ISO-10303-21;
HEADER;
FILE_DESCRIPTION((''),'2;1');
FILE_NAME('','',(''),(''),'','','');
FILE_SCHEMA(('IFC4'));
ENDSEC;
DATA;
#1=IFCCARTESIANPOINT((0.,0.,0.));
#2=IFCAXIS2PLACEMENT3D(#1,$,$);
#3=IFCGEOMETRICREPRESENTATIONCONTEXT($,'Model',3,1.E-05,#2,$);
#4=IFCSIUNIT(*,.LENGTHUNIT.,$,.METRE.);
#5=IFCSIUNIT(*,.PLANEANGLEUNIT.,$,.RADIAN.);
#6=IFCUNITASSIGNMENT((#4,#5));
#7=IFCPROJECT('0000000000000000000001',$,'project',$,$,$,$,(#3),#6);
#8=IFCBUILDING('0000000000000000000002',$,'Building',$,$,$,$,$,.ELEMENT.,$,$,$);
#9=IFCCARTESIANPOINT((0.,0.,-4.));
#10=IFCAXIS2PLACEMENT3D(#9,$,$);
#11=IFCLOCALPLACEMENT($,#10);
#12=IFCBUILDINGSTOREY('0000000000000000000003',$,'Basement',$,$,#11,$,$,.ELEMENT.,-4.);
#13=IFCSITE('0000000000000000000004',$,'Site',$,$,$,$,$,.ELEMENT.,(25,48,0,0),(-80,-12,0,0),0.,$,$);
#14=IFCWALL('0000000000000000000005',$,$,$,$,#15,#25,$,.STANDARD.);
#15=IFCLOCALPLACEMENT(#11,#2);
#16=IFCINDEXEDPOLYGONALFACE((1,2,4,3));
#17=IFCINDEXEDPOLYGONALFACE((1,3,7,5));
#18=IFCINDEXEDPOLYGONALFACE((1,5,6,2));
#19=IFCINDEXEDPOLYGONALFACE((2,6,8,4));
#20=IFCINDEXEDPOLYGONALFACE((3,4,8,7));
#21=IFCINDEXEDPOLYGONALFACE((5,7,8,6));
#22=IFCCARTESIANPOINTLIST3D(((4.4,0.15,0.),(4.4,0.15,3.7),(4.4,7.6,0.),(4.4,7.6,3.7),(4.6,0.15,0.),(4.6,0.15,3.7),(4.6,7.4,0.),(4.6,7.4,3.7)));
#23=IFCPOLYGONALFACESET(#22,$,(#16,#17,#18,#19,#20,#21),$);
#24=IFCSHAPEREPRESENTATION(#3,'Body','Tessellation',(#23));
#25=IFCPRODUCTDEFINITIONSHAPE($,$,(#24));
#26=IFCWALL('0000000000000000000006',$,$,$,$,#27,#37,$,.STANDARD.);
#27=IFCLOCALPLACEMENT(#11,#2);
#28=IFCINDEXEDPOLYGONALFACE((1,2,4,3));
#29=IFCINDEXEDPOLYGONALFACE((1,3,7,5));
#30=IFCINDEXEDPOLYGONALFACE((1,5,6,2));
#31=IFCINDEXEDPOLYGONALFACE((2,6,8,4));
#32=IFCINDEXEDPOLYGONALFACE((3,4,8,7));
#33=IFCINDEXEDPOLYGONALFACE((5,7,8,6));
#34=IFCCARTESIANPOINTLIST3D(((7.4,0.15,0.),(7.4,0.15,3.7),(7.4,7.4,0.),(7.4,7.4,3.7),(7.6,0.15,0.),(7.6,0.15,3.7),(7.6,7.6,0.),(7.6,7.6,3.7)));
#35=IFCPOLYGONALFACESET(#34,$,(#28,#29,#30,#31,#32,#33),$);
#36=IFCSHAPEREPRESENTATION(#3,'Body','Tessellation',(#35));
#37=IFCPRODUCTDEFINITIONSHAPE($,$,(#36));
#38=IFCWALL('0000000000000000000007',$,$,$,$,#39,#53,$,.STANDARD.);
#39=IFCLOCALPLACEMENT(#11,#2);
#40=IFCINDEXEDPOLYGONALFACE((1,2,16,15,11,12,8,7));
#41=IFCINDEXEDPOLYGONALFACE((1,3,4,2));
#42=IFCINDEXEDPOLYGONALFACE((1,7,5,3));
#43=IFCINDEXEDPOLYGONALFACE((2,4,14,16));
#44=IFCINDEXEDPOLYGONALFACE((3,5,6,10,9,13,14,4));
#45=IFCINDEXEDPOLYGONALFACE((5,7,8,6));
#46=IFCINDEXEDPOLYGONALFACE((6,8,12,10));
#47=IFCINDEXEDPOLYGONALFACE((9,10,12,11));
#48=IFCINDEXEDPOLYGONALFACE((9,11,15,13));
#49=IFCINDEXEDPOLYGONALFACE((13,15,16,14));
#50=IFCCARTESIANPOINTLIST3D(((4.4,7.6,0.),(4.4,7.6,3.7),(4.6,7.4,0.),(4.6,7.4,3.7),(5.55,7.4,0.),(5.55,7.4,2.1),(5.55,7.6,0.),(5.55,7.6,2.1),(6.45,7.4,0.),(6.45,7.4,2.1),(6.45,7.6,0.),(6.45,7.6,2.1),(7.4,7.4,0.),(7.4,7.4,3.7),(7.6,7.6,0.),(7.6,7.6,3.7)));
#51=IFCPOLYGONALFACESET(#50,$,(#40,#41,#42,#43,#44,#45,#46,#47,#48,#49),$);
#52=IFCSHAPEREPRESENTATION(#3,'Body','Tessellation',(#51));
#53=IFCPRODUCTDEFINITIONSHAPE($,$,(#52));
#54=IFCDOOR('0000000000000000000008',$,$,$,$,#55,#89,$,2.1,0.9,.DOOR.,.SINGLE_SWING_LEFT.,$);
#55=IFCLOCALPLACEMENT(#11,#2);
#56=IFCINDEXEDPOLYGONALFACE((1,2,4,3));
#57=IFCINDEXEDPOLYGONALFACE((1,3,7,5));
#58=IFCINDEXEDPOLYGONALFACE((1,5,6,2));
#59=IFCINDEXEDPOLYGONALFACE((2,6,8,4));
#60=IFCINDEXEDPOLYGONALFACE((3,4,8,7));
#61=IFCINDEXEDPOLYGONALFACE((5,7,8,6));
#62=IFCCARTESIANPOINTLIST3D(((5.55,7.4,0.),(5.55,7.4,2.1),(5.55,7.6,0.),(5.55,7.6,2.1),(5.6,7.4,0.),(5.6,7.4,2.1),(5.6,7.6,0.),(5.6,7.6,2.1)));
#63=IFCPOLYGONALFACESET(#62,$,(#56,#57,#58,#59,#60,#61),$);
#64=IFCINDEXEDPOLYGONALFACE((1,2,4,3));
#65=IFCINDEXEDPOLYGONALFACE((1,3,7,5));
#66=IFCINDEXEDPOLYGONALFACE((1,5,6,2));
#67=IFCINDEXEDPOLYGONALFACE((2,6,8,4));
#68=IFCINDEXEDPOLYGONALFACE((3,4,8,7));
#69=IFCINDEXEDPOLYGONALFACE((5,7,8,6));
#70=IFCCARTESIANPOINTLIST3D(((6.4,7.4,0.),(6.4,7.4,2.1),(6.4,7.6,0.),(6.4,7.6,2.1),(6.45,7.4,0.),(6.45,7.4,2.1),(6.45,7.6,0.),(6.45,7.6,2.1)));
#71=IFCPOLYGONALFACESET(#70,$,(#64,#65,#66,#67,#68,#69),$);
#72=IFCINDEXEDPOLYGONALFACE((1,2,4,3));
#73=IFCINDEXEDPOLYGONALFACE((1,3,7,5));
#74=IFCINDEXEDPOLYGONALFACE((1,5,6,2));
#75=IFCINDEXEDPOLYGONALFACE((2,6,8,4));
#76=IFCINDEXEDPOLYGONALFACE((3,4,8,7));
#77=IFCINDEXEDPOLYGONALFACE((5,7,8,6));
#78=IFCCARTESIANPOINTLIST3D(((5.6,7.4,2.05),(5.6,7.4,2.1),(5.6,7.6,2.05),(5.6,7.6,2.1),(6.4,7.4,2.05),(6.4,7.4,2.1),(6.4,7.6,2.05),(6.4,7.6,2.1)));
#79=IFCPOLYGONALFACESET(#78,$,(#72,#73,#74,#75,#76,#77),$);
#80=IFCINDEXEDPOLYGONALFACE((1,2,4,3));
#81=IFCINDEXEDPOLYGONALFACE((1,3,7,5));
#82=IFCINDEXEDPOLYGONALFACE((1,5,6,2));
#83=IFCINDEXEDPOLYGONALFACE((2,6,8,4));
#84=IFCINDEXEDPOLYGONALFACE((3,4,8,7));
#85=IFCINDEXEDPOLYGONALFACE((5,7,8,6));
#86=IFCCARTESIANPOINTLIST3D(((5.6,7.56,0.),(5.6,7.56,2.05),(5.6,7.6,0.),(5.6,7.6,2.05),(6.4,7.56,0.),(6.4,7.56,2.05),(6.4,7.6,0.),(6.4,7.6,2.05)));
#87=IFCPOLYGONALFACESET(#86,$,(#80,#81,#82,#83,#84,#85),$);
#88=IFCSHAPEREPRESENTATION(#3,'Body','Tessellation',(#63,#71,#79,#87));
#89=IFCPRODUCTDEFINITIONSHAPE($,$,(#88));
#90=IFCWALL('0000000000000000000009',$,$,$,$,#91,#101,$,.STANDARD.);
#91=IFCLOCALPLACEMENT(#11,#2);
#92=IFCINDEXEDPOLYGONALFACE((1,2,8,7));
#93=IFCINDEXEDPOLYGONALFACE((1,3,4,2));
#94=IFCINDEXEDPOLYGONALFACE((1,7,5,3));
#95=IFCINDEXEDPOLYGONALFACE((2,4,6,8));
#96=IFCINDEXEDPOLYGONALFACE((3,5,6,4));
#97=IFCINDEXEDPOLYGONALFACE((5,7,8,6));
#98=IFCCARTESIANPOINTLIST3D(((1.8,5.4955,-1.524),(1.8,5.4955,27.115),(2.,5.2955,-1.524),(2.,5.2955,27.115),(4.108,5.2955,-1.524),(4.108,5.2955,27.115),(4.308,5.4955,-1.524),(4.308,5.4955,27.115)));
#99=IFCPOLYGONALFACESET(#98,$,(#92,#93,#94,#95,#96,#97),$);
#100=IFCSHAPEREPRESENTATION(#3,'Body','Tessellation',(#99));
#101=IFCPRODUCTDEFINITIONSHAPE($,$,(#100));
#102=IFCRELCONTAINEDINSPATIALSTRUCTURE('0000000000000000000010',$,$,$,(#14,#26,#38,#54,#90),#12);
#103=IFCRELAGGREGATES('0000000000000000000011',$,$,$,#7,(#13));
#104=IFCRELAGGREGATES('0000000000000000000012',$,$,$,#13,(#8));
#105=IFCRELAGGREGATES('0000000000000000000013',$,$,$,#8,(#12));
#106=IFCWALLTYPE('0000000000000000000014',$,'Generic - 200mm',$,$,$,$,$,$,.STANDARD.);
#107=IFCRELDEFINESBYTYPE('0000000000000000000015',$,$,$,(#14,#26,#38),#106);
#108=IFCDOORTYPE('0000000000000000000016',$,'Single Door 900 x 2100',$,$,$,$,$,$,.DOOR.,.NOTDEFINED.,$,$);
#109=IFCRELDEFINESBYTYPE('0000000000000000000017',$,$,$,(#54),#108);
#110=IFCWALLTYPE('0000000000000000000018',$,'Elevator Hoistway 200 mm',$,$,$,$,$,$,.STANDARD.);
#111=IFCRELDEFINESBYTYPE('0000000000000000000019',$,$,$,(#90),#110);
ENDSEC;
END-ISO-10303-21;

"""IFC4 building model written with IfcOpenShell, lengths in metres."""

from ifc_helpers import new_model, si_unit, frame, frame_2d, origin, origin_with_axes, origin_2d, place, context, project, spatial, polyline, rectangle, outline, extrude, type_object, element, fill, save


model = new_model("IFC4")

# Units and contexts
model_context = context("Model", 3, precision=1e-05, world=origin())
ifc_project = project(units=[si_unit("LENGTHUNIT", "METRE"), si_unit("PLANEANGLEUNIT", "RADIAN")], contexts=[model_context])

# Site, building, storey
site = spatial("IfcSite", under=ifc_project, Name="Site", CompositionType="ELEMENT", RefLatitude=(25, 48, 0, 0), RefLongitude=(-80, -12, 0, 0), RefElevation=0.0)
building = spatial("IfcBuilding", under=site, Name="Building", CompositionType="ELEMENT")
storey_placement = place(None, frame((0.0, 0.0, -4.0)))
storey = spatial("IfcBuildingStorey", under=building, at=storey_placement, Name="Basement", CompositionType="ELEMENT", Elevation=-4.0)

# Walls
wall_type_1 = type_object("IfcWallType", Name="Generic - 200mm", PredefinedType="STANDARD")
wall_1_placement = place(None, frame((4.5, 7.5, -4.0), z_axis=(0.0, 0.0, 1.0), x_axis=(0.0, -1.0, 0.0)))
element("IfcWall", 1, at=wall_1_placement, inside=storey, type_object=wall_type_1, PredefinedType="STANDARD", context=model_context, shape_type="SweptSolid", body=[
    extrude(outline(polyline([(-0.1, -0.1), (7.35, -0.1), (7.35, 0.1), (0.1, 0.1), (-0.1, -0.1)])), origin(), (0.0, 0.0, 1.0), 3.7),
])
wall_2_placement = place(None, frame((7.5, 7.5, -4.0), z_axis=(0.0, 0.0, 1.0), x_axis=(0.0, -1.0, 0.0)))
element("IfcWall", 2, at=wall_2_placement, inside=storey, type_object=wall_type_1, PredefinedType="STANDARD", context=model_context, shape_type="SweptSolid", body=[
    extrude(outline(polyline([(0.1, -0.1), (7.35, -0.1), (7.35, 0.1), (-0.1, 0.1), (0.1, -0.1)])), origin(), (0.0, 0.0, 1.0), 3.7),
])

# Wall, opening, door
wall_3_placement = place(None, frame((4.5, 7.5, -4.0), z_axis=(0.0, 0.0, 1.0), x_axis=(1.0, 0.0, 0.0)))
wall_3 = element("IfcWall", 3, at=wall_3_placement, inside=storey, type_object=wall_type_1, PredefinedType="STANDARD", context=model_context, shape_type="SweptSolid", body=[
    extrude(outline(polyline([(0.1, -0.1), (2.9, -0.1), (3.1, 0.1), (-0.1, 0.1), (0.1, -0.1)])), origin(), (0.0, 0.0, 1.0), 3.7),
])
opening_1_placement = place(wall_3_placement, frame((1.5, 0.0, 0.0), z_axis=(0.0, 0.0, 1.0), x_axis=(1.0, 0.0, 0.0)))
opening_1 = element("IfcOpeningElement", 4, at=opening_1_placement, cuts=wall_3, PredefinedType="OPENING", context=model_context, shape_type="SweptSolid", body=[
    extrude(rectangle(XDim=0.9, YDim=0.202, at=origin_2d()), origin(), (0.0, 0.0, 1.0), 2.1),
])
door_type_1 = type_object("IfcDoorType", Name="Single Door 900 x 2100", OperationType="NOTDEFINED", PredefinedType="DOOR")
door_1_placement = place(opening_1_placement, origin_with_axes())
door_1 = element("IfcDoor", 5, at=door_1_placement, inside=storey, type_object=door_type_1, OperationType="SINGLE_SWING_LEFT", OverallHeight=2.1, OverallWidth=0.9, PredefinedType="DOOR", context=model_context, shape_type="SweptSolid", body=[
    extrude(rectangle(XDim=0.05, YDim=0.2, at=frame_2d((-0.425, 0.0))), origin(), (0.0, 0.0, 1.0), 2.1),
    extrude(rectangle(XDim=0.05, YDim=0.2, at=frame_2d((0.425, 0.0))), origin(), (0.0, 0.0, 1.0), 2.1),
    extrude(rectangle(XDim=0.8, YDim=0.2, at=origin_2d()), frame((0.0, 0.0, 2.05)), (0.0, 0.0, 1.0), 0.05),
    extrude(rectangle(XDim=0.8, YDim=0.04, at=frame_2d((0.0, 0.08))), origin(), (0.0, 0.0, 1.0), 2.05),
])
fill(opening_1, door_1)

# Shared definitions
wall_type_2 = type_object("IfcWallType", Name="Elevator Hoistway 200 mm", PredefinedType="STANDARD")

# Wall
wall_4_placement = place(None, frame((4.208, 5.3955, -5.524), z_axis=(0.0, 0.0, 1.0), x_axis=(-1.0, 0.0, 0.0)))
element("IfcWall", 6, at=wall_4_placement, inside=storey, type_object=wall_type_2, PredefinedType="STANDARD", context=model_context, shape_type="SweptSolid", body=[
    extrude(outline(polyline([(-0.1, -0.1), (2.408, -0.1), (2.208, 0.1), (0.1, 0.1), (-0.1, -0.1)])), origin(), (0.0, 0.0, 1.0), 28.639),
])

save(model, "model.ifc")
